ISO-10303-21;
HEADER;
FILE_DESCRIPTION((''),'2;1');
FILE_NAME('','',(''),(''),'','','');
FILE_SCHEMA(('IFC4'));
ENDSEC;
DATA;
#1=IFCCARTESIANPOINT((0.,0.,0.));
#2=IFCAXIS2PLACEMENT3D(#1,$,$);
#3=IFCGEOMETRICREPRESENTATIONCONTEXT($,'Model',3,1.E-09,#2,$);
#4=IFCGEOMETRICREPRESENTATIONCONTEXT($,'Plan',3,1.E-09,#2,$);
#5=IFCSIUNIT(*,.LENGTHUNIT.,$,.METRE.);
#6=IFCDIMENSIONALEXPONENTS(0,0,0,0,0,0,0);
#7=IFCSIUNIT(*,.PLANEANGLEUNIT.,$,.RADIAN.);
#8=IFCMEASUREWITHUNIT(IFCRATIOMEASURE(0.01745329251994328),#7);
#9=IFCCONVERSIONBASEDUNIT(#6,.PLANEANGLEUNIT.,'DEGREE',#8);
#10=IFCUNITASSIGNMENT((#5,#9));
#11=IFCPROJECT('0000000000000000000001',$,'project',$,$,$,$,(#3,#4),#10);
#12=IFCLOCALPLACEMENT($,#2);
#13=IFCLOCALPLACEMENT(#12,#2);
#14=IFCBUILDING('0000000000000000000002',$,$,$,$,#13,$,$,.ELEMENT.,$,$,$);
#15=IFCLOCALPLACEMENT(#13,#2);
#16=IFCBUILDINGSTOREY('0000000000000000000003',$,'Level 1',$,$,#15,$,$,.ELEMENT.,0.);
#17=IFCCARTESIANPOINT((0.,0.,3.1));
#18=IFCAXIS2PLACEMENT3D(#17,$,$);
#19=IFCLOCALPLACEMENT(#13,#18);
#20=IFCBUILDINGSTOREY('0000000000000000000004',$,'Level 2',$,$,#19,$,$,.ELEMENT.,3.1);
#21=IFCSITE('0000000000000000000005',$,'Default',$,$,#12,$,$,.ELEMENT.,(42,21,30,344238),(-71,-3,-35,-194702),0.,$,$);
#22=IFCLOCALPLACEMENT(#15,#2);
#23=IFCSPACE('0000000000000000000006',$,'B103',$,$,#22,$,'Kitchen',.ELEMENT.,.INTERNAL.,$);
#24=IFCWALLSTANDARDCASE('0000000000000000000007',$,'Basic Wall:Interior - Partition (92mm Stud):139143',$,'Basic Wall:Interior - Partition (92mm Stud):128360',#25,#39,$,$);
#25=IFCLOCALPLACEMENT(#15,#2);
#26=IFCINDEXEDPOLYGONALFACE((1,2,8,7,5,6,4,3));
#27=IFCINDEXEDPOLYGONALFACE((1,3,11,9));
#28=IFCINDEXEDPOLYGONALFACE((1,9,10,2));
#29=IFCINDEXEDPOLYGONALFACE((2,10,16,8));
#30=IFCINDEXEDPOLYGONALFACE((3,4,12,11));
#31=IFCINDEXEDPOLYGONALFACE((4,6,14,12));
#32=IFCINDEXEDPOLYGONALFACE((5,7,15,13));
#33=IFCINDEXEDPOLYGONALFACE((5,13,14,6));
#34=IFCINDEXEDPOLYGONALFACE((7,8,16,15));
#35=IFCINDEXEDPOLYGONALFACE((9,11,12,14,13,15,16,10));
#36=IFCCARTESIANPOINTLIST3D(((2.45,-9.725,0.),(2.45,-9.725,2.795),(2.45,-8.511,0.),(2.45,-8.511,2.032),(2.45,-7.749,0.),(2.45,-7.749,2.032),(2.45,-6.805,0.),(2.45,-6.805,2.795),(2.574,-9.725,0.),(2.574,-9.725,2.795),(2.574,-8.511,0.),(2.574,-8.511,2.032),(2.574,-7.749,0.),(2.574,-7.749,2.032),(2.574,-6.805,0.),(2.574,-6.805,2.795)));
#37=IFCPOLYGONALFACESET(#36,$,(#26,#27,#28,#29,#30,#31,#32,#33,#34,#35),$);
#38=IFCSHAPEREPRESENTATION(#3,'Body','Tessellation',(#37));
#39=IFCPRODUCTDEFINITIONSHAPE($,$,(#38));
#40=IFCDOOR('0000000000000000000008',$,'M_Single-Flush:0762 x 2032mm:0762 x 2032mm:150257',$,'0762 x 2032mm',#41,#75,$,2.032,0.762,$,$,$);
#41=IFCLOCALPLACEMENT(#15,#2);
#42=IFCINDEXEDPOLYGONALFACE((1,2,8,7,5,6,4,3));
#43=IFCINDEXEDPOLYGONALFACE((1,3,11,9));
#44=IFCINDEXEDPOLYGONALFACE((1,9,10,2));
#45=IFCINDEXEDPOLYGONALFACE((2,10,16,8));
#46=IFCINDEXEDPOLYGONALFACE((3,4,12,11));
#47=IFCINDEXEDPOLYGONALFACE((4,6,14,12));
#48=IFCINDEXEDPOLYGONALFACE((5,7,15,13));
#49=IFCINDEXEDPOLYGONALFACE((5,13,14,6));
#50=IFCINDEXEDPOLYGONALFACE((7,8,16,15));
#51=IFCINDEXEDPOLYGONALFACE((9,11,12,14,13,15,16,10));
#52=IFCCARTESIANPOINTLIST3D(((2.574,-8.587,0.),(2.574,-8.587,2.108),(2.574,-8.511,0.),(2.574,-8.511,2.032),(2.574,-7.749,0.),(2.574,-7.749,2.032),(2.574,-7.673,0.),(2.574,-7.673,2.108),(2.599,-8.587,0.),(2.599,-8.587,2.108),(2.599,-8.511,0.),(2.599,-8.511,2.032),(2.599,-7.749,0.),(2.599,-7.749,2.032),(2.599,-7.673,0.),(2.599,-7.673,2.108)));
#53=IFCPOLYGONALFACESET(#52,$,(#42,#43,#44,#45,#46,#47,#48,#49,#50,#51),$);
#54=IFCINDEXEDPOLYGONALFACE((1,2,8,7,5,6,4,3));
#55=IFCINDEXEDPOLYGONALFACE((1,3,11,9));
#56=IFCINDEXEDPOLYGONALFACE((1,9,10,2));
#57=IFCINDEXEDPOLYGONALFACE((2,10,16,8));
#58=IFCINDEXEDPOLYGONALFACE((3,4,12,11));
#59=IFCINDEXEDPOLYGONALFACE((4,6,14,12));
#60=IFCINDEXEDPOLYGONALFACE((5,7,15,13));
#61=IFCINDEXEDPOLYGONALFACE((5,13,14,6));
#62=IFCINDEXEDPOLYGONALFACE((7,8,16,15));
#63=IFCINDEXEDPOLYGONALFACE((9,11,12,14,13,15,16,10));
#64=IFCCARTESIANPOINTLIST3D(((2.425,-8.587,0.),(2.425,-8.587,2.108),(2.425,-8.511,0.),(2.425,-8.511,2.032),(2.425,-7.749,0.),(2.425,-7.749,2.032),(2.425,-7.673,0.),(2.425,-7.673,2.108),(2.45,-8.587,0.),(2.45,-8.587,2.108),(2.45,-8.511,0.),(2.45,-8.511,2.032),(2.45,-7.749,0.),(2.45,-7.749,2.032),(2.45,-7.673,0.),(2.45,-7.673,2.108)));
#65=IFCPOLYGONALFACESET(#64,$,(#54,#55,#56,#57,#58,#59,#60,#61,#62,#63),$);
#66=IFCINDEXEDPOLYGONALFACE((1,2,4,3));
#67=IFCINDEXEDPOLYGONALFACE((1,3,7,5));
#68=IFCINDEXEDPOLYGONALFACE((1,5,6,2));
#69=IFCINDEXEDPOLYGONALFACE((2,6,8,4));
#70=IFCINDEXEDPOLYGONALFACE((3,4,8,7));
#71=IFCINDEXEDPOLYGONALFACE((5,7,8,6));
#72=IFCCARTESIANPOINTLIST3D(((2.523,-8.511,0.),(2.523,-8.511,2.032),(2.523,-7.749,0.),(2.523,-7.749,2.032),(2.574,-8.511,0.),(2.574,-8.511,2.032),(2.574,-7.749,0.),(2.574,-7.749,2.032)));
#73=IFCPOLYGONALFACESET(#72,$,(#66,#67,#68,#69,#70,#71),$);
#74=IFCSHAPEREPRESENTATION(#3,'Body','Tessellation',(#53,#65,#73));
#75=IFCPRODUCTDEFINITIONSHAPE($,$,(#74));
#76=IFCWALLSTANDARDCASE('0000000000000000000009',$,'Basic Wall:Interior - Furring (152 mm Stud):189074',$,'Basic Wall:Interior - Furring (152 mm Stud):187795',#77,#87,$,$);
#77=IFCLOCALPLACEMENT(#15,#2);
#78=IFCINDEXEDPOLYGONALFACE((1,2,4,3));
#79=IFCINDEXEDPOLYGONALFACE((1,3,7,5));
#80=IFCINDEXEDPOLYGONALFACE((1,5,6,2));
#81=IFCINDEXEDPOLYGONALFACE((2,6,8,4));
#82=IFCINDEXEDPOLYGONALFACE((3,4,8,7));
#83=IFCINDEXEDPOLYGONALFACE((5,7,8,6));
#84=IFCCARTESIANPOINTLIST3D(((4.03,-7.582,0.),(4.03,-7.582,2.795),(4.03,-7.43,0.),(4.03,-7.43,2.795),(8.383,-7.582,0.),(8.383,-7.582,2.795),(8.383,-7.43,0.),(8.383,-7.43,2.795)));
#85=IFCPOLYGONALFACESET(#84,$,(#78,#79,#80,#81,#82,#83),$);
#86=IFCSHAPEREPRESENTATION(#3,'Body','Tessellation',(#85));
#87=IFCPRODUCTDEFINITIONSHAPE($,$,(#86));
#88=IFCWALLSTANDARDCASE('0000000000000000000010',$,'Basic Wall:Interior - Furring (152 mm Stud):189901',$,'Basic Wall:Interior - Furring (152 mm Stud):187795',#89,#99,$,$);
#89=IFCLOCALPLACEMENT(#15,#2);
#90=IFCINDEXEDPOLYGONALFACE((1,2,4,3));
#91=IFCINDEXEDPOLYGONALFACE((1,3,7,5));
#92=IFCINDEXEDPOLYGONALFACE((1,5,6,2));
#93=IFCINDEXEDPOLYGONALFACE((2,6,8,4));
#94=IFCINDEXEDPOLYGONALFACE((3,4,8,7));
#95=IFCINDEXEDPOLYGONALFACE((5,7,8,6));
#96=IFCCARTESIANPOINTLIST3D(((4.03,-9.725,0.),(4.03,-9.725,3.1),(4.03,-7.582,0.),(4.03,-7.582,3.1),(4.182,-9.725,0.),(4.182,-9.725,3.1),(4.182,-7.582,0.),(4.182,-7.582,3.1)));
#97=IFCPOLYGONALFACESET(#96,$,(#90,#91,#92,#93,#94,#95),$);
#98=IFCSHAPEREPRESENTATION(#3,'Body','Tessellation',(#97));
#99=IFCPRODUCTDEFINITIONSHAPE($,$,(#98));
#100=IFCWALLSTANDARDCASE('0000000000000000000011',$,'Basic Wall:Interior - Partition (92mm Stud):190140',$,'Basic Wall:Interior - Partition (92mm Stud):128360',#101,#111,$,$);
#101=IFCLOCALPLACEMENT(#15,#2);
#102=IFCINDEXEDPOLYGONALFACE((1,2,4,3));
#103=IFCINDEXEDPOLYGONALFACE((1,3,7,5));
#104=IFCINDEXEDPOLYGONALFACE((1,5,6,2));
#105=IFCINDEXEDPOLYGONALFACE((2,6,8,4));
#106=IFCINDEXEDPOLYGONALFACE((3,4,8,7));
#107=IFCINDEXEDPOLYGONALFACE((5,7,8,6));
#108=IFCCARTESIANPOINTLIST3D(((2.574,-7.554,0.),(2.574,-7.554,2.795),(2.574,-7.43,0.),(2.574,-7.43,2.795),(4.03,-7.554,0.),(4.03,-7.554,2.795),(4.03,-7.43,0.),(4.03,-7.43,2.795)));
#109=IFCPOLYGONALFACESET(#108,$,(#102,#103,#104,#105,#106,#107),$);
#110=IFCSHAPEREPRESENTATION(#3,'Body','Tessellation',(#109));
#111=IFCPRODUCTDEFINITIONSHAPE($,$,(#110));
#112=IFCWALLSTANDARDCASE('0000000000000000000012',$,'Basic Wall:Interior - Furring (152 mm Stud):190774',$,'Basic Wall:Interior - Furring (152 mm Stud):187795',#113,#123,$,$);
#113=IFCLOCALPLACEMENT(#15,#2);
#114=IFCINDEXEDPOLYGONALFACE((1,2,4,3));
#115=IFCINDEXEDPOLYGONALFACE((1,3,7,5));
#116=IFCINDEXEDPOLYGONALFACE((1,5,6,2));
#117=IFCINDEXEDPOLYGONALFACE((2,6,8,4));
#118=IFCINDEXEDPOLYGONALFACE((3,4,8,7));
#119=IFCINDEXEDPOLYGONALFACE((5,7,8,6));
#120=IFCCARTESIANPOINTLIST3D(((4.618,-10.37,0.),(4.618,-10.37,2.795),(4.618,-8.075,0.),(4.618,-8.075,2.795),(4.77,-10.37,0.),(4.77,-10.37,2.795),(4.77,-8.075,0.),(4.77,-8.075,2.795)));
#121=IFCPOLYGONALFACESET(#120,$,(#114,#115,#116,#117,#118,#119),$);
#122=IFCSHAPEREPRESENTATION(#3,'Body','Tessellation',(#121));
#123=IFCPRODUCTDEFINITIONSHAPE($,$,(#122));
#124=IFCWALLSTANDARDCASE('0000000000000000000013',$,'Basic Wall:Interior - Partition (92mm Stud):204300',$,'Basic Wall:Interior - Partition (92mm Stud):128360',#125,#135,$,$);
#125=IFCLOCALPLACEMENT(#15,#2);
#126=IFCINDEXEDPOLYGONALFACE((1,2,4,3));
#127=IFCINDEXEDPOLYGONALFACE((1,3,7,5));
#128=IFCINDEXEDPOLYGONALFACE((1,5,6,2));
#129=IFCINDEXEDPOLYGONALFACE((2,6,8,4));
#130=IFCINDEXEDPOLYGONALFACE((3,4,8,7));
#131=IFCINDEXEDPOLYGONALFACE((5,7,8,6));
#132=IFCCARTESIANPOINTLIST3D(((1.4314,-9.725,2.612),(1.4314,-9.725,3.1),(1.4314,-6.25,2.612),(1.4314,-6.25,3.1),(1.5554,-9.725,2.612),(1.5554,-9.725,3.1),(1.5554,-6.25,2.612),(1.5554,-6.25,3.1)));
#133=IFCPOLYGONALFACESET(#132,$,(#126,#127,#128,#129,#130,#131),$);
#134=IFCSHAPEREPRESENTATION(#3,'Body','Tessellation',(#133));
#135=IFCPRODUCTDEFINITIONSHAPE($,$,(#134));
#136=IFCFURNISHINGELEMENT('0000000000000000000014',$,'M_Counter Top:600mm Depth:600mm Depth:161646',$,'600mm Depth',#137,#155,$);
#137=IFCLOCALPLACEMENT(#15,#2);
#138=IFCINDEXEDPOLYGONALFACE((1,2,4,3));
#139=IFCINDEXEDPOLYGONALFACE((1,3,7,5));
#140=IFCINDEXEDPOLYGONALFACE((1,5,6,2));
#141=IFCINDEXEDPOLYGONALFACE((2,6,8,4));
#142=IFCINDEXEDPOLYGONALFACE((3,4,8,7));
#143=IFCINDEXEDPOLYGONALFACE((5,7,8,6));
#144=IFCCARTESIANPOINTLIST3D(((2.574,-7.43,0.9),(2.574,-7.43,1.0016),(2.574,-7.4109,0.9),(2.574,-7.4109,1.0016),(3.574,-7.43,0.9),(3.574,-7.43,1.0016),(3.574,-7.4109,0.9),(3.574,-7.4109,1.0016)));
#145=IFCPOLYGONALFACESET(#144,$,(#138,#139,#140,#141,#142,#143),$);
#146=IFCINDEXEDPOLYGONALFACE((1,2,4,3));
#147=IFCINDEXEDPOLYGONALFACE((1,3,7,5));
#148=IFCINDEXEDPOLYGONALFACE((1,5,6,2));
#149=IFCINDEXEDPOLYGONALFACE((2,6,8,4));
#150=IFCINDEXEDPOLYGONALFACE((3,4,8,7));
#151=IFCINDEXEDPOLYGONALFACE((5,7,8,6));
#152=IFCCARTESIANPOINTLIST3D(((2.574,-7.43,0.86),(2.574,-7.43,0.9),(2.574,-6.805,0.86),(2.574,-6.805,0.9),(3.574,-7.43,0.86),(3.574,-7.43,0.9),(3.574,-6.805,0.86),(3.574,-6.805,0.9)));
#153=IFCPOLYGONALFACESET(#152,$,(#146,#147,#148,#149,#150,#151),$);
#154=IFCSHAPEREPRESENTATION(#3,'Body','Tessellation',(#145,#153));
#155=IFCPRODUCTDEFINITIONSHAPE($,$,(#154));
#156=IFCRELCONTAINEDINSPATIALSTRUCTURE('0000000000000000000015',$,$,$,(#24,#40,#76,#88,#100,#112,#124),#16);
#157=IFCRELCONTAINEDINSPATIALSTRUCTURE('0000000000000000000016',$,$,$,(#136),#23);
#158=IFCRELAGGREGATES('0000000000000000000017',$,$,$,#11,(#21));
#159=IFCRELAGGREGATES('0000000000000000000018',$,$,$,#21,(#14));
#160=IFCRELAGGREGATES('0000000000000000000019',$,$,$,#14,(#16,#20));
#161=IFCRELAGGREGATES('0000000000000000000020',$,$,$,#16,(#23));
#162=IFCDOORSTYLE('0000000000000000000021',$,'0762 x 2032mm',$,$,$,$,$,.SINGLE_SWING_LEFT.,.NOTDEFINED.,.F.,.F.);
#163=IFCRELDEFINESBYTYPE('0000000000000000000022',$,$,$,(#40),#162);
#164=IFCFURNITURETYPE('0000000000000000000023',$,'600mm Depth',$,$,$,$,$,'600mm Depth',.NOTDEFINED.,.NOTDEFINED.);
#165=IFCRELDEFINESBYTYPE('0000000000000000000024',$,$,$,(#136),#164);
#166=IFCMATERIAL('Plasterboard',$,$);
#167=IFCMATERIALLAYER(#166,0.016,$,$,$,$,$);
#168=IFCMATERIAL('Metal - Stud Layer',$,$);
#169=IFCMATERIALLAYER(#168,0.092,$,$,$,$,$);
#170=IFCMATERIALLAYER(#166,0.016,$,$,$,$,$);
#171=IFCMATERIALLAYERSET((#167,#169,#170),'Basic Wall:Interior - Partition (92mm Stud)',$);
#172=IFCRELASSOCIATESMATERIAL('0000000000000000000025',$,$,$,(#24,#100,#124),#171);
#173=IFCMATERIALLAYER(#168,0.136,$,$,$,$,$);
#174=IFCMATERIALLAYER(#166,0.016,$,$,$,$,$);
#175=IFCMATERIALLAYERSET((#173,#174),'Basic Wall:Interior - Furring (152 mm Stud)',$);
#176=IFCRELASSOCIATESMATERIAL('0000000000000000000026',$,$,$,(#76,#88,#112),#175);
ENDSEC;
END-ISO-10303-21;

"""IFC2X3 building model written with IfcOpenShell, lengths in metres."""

from ifc_helpers import new_model, entity, si_unit, converted_unit, frame, frame_2d, origin, origin_2d_with_axis, place, context, project, spatial, polyline, rectangle, outline, extrude, clip, bounded_halfspace, source, transform, mapped, material, layer, layer_set, layer_usage, type_object, type_shapes, element, fill, save


model = new_model("IFC2X3")

# Units and contexts
model_context = context("Model", 3, precision=1e-09, world=origin())
plan_context = context("Plan", 3, precision=1e-09, world=origin())
ifc_project = project(units=[si_unit("LENGTHUNIT", "METRE"), converted_unit("PLANEANGLEUNIT", "DEGREE", entity("IfcRatioMeasure", 0.01745329251994328), si_unit("PLANEANGLEUNIT", "RADIAN"), dimensions=[0, 0, 0, 0, 0, 0, 0])], contexts=[model_context, plan_context])

# Site, building, storey
site_placement = place(None, origin())
site = spatial("IfcSite", under=ifc_project, at=site_placement, Name="Default", CompositionType="ELEMENT", RefLatitude=(42, 21, 30, 344238), RefLongitude=(-71, -3, -35, -194702), RefElevation=0.0)
building_placement = place(site_placement, origin())
building = spatial("IfcBuilding", under=site, at=building_placement, CompositionType="ELEMENT")
storey_1_placement = place(building_placement, origin())
storey_1 = spatial("IfcBuildingStorey", under=building, at=storey_1_placement, Name="Level 1", CompositionType="ELEMENT", Elevation=0.0)

# Shared definitions
ifc_material_1 = material(Name="Metal - Stud Layer")
ifc_material_2 = material(Name="Plasterboard")

# Shared definitions
ifc_layer_1 = layer(ifc_material_2, 0.016)
ifc_layer_2 = layer(ifc_material_1, 0.092)
ifc_layer_3 = layer(ifc_material_2, 0.016)
ifc_layer_set_1 = layer_set([ifc_layer_1, ifc_layer_2, ifc_layer_3], Name="Basic Wall:Interior - Partition (92mm Stud)")

# Wall, opening, door
ifc_layer_usage_1 = layer_usage(ifc_layer_set_1, "AXIS2", "NEGATIVE", 0.062)
wall_1_placement = place(storey_1_placement, frame((2.512, -6.805, 0.0), z_axis=(0.0, 0.0, 1.0), x_axis=(0.0, -1.0, 0.0)))
wall_1 = element("IfcWallStandardCase", 1, at=wall_1_placement, inside=storey_1, material=ifc_layer_usage_1, Name="Basic Wall:Interior - Partition (92mm Stud):139143", ObjectType="Basic Wall:Interior - Partition (92mm Stud):128360", context=model_context, shape_type="SweptSolid", body=[
    extrude(rectangle(XDim=2.92, YDim=0.124, at=frame_2d((1.46, 0.0), x_axis=(-1.0, 0.0))), origin(), (0.0, 0.0, 1.0), 2.795),
])
opening_1_placement = place(wall_1_placement, frame((0.944, -0.062, 0.0)))
opening_1 = element("IfcOpeningElement", 2, at=opening_1_placement, cuts=wall_1, ObjectType="Opening", context=model_context, shape_type="SweptSolid", body=[
    extrude(rectangle(XDim=0.762, YDim=2.032, at=frame_2d((1.016, 0.381), x_axis=(0.0, -1.0))), frame((0.0, 0.0, 0.0), z_axis=(0.0, 1.0, 0.0), x_axis=(0.0, 0.0, 1.0)), (0.0, 0.0, 1.0), 0.124),
])
door_style_1 = type_object("IfcDoorStyle", Name="0762 x 2032mm", ConstructionType="NOTDEFINED", OperationType="SINGLE_SWING_LEFT", ParameterTakesPrecedence=False, Sizeable=False)
shared_shape_1 = source(origin(), model_context, "Body", "SweptSolid", [
    extrude(outline(polyline([(-0.457, -1.073), (0.457, -1.073), (0.457, 1.035), (0.381, 1.035), (0.381, -0.997), (-0.381, -0.997), (-0.381, 1.035), (-0.457, 1.035), (-0.457, -1.073)])), frame((0.381, 0.149, 1.035), z_axis=(0.0, -1.0, 0.0), x_axis=(-1.0, 0.0, 0.0)), (0.0, 0.0, 1.0), 0.025),
    extrude(outline(polyline([(-1.073, -0.457), (1.035, -0.457), (1.035, -0.381), (-0.997, -0.381), (-0.997, 0.381), (1.035, 0.381), (1.035, 0.457), (-1.073, 0.457), (-1.073, -0.457)])), frame((0.381, 0.0, 1.035), z_axis=(0.0, -1.0, 0.0), x_axis=(0.0, 0.0, -1.0)), (0.0, 0.0, 1.0), 0.025),
    extrude(rectangle(XDim=0.762, YDim=0.051, at=origin_2d_with_axis()), frame((0.381, 0.0985, 0.0)), (0.0, 0.0, 1.0), 2.032),
])
type_shapes(door_style_1, [shared_shape_1])
door_1_placement = place(opening_1_placement, origin())
door_1 = element("IfcDoor", 3, at=door_1_placement, inside=storey_1, type_object=door_style_1, Name="M_Single-Flush:0762 x 2032mm:0762 x 2032mm:150257", ObjectType="0762 x 2032mm", OverallHeight=2.032, OverallWidth=0.762, context=model_context, shape_type="MappedRepresentation", body=[
    mapped(shared_shape_1, transform((0.0, 0.0, 0.0), scale=1.0)),
])
fill(opening_1, door_1)

# Shared definitions
storey_2_placement = place(building_placement, frame((0.0, 0.0, 3.1)))
storey_2 = spatial("IfcBuildingStorey", under=building, at=storey_2_placement, Name="Level 2", CompositionType="ELEMENT", Elevation=3.1)

# Walls
ifc_layer_4 = layer(ifc_material_1, 0.136)
ifc_layer_5 = layer(ifc_material_2, 0.016)
ifc_layer_set_2 = layer_set([ifc_layer_4, ifc_layer_5], Name="Basic Wall:Interior - Furring (152 mm Stud)")
ifc_layer_usage_2 = layer_usage(ifc_layer_set_2, "AXIS2", "NEGATIVE", 0.076)
wall_2_placement = place(storey_1_placement, frame((8.383, -7.506, 0.0), z_axis=(0.0, 0.0, 1.0), x_axis=(-1.0, 0.0, 0.0)))
element("IfcWallStandardCase", 4, at=wall_2_placement, inside=storey_1, material=ifc_layer_usage_2, Name="Basic Wall:Interior - Furring (152 mm Stud):189074", ObjectType="Basic Wall:Interior - Furring (152 mm Stud):187795", context=model_context, shape_type="Clipping", body=[
    clip(extrude(rectangle(XDim=4.353, YDim=0.152, at=frame_2d((2.1765, 0.0), x_axis=(-1.0, 0.0))), origin(), (0.0, 0.0, 1.0), 2.795), bounded_halfspace(frame((0.0, -0.076, 2.795), z_axis=(0.0, 0.0, -1.0), x_axis=(0.0, 1.0, 0.0)), True, frame((0.0, -0.076, 2.795)), polyline([(0.0, 0.0), (3.708, 0.0), (3.708, 0.152), (0.0, 0.152), (0.0, 0.0)]))),
])
ifc_layer_usage_3 = layer_usage(ifc_layer_set_2, "AXIS2", "POSITIVE", -0.076)
wall_3_placement = place(storey_1_placement, frame((4.106, -9.725, 0.0), z_axis=(0.0, 0.0, 1.0), x_axis=(0.0, 1.0, 0.0)))
element("IfcWallStandardCase", 5, at=wall_3_placement, inside=storey_1, material=ifc_layer_usage_3, Name="Basic Wall:Interior - Furring (152 mm Stud):189901", ObjectType="Basic Wall:Interior - Furring (152 mm Stud):187795", context=model_context, shape_type="SweptSolid", body=[
    extrude(rectangle(XDim=2.143, YDim=0.152, at=frame_2d((1.0715, 0.0), x_axis=(-1.0, 0.0))), origin(), (0.0, 0.0, 1.0), 3.1),
])
ifc_layer_usage_4 = layer_usage(ifc_layer_set_1, "AXIS2", "NEGATIVE", 0.062)
wall_4_placement = place(storey_1_placement, frame((4.03, -7.492, 0.0), z_axis=(0.0, 0.0, 1.0), x_axis=(-1.0, 0.0, 0.0)))
element("IfcWallStandardCase", 6, at=wall_4_placement, inside=storey_1, material=ifc_layer_usage_4, Name="Basic Wall:Interior - Partition (92mm Stud):190140", ObjectType="Basic Wall:Interior - Partition (92mm Stud):128360", context=model_context, shape_type="SweptSolid", body=[
    extrude(rectangle(XDim=1.456, YDim=0.124, at=frame_2d((0.728, 0.0), x_axis=(-1.0, 0.0))), origin(), (0.0, 0.0, 1.0), 2.795),
])
ifc_layer_usage_5 = layer_usage(ifc_layer_set_2, "AXIS2", "POSITIVE", -0.076)
wall_5_placement = place(storey_1_placement, frame((4.694, -8.075, 0.0), z_axis=(0.0, 0.0, 1.0), x_axis=(0.0, -1.0, 0.0)))
element("IfcWallStandardCase", 7, at=wall_5_placement, inside=storey_1, material=ifc_layer_usage_5, Name="Basic Wall:Interior - Furring (152 mm Stud):190774", ObjectType="Basic Wall:Interior - Furring (152 mm Stud):187795", context=model_context, shape_type="SweptSolid", body=[
    extrude(rectangle(XDim=2.295, YDim=0.152, at=frame_2d((1.1475, 0.0), x_axis=(-1.0, 0.0))), origin(), (0.0, 0.0, 1.0), 2.795),
])
ifc_layer_usage_6 = layer_usage(ifc_layer_set_1, "AXIS2", "NEGATIVE", 0.062)
wall_6_placement = place(storey_1_placement, frame((1.4934, -6.25, 2.612), z_axis=(0.0, 0.0, 1.0), x_axis=(0.0, -1.0, 0.0)))
element("IfcWallStandardCase", 8, at=wall_6_placement, inside=storey_1, material=ifc_layer_usage_6, Name="Basic Wall:Interior - Partition (92mm Stud):204300", ObjectType="Basic Wall:Interior - Partition (92mm Stud):128360", context=model_context, shape_type="SweptSolid", body=[
    extrude(rectangle(XDim=3.475, YDim=0.124, at=frame_2d((1.7375, 0.0), x_axis=(-1.0, 0.0))), origin(), (0.0, 0.0, 1.0), 0.488),
])

# Shared definitions
space_1_placement = place(storey_1_placement, origin())
space_1 = spatial("IfcSpace", under=storey_1, at=space_1_placement, Name="B103", LongName="Kitchen", CompositionType="ELEMENT", InteriorOrExteriorSpace="INTERNAL")

# Furnishing element
furniture_type_1 = type_object("IfcFurnitureType", Name="600mm Depth", ElementType="600mm Depth", AssemblyPlace="NOTDEFINED")
shared_shape_2 = source(origin(), model_context, "Body", "SweptSolid", [
    extrude(rectangle(XDim=0.0191, YDim=1.0, at=origin_2d_with_axis()), frame((-0.7005, -0.0095, 0.9), z_axis=(0.0, 0.0, 1.0), x_axis=(0.0, -1.0, 0.0)), (0.0, 0.0, 1.0), 0.1016),
    extrude(rectangle(XDim=1.0, YDim=0.625, at=origin_2d_with_axis()), frame((-0.7005, -0.3125, 0.86), z_axis=(0.0, 0.0, 1.0), x_axis=(-1.0, 0.0, 0.0)), (0.0, 0.0, 1.0), 0.04),
])
type_shapes(furniture_type_1, [shared_shape_2])
furnishing_1_placement = place(space_1_placement, frame((2.3735, -7.43, 0.0), z_axis=(0.0, 0.0, 1.0), x_axis=(-1.0, 0.0, 0.0)))
element("IfcFurnishingElement", 9, at=furnishing_1_placement, inside=space_1, type_object=furniture_type_1, Name="M_Counter Top:600mm Depth:600mm Depth:161646", ObjectType="600mm Depth", context=model_context, shape_type="MappedRepresentation", body=[
    mapped(shared_shape_2, transform((0.0, 0.0, 0.0), scale=1.0)),
])

save(model, "model.ifc")
